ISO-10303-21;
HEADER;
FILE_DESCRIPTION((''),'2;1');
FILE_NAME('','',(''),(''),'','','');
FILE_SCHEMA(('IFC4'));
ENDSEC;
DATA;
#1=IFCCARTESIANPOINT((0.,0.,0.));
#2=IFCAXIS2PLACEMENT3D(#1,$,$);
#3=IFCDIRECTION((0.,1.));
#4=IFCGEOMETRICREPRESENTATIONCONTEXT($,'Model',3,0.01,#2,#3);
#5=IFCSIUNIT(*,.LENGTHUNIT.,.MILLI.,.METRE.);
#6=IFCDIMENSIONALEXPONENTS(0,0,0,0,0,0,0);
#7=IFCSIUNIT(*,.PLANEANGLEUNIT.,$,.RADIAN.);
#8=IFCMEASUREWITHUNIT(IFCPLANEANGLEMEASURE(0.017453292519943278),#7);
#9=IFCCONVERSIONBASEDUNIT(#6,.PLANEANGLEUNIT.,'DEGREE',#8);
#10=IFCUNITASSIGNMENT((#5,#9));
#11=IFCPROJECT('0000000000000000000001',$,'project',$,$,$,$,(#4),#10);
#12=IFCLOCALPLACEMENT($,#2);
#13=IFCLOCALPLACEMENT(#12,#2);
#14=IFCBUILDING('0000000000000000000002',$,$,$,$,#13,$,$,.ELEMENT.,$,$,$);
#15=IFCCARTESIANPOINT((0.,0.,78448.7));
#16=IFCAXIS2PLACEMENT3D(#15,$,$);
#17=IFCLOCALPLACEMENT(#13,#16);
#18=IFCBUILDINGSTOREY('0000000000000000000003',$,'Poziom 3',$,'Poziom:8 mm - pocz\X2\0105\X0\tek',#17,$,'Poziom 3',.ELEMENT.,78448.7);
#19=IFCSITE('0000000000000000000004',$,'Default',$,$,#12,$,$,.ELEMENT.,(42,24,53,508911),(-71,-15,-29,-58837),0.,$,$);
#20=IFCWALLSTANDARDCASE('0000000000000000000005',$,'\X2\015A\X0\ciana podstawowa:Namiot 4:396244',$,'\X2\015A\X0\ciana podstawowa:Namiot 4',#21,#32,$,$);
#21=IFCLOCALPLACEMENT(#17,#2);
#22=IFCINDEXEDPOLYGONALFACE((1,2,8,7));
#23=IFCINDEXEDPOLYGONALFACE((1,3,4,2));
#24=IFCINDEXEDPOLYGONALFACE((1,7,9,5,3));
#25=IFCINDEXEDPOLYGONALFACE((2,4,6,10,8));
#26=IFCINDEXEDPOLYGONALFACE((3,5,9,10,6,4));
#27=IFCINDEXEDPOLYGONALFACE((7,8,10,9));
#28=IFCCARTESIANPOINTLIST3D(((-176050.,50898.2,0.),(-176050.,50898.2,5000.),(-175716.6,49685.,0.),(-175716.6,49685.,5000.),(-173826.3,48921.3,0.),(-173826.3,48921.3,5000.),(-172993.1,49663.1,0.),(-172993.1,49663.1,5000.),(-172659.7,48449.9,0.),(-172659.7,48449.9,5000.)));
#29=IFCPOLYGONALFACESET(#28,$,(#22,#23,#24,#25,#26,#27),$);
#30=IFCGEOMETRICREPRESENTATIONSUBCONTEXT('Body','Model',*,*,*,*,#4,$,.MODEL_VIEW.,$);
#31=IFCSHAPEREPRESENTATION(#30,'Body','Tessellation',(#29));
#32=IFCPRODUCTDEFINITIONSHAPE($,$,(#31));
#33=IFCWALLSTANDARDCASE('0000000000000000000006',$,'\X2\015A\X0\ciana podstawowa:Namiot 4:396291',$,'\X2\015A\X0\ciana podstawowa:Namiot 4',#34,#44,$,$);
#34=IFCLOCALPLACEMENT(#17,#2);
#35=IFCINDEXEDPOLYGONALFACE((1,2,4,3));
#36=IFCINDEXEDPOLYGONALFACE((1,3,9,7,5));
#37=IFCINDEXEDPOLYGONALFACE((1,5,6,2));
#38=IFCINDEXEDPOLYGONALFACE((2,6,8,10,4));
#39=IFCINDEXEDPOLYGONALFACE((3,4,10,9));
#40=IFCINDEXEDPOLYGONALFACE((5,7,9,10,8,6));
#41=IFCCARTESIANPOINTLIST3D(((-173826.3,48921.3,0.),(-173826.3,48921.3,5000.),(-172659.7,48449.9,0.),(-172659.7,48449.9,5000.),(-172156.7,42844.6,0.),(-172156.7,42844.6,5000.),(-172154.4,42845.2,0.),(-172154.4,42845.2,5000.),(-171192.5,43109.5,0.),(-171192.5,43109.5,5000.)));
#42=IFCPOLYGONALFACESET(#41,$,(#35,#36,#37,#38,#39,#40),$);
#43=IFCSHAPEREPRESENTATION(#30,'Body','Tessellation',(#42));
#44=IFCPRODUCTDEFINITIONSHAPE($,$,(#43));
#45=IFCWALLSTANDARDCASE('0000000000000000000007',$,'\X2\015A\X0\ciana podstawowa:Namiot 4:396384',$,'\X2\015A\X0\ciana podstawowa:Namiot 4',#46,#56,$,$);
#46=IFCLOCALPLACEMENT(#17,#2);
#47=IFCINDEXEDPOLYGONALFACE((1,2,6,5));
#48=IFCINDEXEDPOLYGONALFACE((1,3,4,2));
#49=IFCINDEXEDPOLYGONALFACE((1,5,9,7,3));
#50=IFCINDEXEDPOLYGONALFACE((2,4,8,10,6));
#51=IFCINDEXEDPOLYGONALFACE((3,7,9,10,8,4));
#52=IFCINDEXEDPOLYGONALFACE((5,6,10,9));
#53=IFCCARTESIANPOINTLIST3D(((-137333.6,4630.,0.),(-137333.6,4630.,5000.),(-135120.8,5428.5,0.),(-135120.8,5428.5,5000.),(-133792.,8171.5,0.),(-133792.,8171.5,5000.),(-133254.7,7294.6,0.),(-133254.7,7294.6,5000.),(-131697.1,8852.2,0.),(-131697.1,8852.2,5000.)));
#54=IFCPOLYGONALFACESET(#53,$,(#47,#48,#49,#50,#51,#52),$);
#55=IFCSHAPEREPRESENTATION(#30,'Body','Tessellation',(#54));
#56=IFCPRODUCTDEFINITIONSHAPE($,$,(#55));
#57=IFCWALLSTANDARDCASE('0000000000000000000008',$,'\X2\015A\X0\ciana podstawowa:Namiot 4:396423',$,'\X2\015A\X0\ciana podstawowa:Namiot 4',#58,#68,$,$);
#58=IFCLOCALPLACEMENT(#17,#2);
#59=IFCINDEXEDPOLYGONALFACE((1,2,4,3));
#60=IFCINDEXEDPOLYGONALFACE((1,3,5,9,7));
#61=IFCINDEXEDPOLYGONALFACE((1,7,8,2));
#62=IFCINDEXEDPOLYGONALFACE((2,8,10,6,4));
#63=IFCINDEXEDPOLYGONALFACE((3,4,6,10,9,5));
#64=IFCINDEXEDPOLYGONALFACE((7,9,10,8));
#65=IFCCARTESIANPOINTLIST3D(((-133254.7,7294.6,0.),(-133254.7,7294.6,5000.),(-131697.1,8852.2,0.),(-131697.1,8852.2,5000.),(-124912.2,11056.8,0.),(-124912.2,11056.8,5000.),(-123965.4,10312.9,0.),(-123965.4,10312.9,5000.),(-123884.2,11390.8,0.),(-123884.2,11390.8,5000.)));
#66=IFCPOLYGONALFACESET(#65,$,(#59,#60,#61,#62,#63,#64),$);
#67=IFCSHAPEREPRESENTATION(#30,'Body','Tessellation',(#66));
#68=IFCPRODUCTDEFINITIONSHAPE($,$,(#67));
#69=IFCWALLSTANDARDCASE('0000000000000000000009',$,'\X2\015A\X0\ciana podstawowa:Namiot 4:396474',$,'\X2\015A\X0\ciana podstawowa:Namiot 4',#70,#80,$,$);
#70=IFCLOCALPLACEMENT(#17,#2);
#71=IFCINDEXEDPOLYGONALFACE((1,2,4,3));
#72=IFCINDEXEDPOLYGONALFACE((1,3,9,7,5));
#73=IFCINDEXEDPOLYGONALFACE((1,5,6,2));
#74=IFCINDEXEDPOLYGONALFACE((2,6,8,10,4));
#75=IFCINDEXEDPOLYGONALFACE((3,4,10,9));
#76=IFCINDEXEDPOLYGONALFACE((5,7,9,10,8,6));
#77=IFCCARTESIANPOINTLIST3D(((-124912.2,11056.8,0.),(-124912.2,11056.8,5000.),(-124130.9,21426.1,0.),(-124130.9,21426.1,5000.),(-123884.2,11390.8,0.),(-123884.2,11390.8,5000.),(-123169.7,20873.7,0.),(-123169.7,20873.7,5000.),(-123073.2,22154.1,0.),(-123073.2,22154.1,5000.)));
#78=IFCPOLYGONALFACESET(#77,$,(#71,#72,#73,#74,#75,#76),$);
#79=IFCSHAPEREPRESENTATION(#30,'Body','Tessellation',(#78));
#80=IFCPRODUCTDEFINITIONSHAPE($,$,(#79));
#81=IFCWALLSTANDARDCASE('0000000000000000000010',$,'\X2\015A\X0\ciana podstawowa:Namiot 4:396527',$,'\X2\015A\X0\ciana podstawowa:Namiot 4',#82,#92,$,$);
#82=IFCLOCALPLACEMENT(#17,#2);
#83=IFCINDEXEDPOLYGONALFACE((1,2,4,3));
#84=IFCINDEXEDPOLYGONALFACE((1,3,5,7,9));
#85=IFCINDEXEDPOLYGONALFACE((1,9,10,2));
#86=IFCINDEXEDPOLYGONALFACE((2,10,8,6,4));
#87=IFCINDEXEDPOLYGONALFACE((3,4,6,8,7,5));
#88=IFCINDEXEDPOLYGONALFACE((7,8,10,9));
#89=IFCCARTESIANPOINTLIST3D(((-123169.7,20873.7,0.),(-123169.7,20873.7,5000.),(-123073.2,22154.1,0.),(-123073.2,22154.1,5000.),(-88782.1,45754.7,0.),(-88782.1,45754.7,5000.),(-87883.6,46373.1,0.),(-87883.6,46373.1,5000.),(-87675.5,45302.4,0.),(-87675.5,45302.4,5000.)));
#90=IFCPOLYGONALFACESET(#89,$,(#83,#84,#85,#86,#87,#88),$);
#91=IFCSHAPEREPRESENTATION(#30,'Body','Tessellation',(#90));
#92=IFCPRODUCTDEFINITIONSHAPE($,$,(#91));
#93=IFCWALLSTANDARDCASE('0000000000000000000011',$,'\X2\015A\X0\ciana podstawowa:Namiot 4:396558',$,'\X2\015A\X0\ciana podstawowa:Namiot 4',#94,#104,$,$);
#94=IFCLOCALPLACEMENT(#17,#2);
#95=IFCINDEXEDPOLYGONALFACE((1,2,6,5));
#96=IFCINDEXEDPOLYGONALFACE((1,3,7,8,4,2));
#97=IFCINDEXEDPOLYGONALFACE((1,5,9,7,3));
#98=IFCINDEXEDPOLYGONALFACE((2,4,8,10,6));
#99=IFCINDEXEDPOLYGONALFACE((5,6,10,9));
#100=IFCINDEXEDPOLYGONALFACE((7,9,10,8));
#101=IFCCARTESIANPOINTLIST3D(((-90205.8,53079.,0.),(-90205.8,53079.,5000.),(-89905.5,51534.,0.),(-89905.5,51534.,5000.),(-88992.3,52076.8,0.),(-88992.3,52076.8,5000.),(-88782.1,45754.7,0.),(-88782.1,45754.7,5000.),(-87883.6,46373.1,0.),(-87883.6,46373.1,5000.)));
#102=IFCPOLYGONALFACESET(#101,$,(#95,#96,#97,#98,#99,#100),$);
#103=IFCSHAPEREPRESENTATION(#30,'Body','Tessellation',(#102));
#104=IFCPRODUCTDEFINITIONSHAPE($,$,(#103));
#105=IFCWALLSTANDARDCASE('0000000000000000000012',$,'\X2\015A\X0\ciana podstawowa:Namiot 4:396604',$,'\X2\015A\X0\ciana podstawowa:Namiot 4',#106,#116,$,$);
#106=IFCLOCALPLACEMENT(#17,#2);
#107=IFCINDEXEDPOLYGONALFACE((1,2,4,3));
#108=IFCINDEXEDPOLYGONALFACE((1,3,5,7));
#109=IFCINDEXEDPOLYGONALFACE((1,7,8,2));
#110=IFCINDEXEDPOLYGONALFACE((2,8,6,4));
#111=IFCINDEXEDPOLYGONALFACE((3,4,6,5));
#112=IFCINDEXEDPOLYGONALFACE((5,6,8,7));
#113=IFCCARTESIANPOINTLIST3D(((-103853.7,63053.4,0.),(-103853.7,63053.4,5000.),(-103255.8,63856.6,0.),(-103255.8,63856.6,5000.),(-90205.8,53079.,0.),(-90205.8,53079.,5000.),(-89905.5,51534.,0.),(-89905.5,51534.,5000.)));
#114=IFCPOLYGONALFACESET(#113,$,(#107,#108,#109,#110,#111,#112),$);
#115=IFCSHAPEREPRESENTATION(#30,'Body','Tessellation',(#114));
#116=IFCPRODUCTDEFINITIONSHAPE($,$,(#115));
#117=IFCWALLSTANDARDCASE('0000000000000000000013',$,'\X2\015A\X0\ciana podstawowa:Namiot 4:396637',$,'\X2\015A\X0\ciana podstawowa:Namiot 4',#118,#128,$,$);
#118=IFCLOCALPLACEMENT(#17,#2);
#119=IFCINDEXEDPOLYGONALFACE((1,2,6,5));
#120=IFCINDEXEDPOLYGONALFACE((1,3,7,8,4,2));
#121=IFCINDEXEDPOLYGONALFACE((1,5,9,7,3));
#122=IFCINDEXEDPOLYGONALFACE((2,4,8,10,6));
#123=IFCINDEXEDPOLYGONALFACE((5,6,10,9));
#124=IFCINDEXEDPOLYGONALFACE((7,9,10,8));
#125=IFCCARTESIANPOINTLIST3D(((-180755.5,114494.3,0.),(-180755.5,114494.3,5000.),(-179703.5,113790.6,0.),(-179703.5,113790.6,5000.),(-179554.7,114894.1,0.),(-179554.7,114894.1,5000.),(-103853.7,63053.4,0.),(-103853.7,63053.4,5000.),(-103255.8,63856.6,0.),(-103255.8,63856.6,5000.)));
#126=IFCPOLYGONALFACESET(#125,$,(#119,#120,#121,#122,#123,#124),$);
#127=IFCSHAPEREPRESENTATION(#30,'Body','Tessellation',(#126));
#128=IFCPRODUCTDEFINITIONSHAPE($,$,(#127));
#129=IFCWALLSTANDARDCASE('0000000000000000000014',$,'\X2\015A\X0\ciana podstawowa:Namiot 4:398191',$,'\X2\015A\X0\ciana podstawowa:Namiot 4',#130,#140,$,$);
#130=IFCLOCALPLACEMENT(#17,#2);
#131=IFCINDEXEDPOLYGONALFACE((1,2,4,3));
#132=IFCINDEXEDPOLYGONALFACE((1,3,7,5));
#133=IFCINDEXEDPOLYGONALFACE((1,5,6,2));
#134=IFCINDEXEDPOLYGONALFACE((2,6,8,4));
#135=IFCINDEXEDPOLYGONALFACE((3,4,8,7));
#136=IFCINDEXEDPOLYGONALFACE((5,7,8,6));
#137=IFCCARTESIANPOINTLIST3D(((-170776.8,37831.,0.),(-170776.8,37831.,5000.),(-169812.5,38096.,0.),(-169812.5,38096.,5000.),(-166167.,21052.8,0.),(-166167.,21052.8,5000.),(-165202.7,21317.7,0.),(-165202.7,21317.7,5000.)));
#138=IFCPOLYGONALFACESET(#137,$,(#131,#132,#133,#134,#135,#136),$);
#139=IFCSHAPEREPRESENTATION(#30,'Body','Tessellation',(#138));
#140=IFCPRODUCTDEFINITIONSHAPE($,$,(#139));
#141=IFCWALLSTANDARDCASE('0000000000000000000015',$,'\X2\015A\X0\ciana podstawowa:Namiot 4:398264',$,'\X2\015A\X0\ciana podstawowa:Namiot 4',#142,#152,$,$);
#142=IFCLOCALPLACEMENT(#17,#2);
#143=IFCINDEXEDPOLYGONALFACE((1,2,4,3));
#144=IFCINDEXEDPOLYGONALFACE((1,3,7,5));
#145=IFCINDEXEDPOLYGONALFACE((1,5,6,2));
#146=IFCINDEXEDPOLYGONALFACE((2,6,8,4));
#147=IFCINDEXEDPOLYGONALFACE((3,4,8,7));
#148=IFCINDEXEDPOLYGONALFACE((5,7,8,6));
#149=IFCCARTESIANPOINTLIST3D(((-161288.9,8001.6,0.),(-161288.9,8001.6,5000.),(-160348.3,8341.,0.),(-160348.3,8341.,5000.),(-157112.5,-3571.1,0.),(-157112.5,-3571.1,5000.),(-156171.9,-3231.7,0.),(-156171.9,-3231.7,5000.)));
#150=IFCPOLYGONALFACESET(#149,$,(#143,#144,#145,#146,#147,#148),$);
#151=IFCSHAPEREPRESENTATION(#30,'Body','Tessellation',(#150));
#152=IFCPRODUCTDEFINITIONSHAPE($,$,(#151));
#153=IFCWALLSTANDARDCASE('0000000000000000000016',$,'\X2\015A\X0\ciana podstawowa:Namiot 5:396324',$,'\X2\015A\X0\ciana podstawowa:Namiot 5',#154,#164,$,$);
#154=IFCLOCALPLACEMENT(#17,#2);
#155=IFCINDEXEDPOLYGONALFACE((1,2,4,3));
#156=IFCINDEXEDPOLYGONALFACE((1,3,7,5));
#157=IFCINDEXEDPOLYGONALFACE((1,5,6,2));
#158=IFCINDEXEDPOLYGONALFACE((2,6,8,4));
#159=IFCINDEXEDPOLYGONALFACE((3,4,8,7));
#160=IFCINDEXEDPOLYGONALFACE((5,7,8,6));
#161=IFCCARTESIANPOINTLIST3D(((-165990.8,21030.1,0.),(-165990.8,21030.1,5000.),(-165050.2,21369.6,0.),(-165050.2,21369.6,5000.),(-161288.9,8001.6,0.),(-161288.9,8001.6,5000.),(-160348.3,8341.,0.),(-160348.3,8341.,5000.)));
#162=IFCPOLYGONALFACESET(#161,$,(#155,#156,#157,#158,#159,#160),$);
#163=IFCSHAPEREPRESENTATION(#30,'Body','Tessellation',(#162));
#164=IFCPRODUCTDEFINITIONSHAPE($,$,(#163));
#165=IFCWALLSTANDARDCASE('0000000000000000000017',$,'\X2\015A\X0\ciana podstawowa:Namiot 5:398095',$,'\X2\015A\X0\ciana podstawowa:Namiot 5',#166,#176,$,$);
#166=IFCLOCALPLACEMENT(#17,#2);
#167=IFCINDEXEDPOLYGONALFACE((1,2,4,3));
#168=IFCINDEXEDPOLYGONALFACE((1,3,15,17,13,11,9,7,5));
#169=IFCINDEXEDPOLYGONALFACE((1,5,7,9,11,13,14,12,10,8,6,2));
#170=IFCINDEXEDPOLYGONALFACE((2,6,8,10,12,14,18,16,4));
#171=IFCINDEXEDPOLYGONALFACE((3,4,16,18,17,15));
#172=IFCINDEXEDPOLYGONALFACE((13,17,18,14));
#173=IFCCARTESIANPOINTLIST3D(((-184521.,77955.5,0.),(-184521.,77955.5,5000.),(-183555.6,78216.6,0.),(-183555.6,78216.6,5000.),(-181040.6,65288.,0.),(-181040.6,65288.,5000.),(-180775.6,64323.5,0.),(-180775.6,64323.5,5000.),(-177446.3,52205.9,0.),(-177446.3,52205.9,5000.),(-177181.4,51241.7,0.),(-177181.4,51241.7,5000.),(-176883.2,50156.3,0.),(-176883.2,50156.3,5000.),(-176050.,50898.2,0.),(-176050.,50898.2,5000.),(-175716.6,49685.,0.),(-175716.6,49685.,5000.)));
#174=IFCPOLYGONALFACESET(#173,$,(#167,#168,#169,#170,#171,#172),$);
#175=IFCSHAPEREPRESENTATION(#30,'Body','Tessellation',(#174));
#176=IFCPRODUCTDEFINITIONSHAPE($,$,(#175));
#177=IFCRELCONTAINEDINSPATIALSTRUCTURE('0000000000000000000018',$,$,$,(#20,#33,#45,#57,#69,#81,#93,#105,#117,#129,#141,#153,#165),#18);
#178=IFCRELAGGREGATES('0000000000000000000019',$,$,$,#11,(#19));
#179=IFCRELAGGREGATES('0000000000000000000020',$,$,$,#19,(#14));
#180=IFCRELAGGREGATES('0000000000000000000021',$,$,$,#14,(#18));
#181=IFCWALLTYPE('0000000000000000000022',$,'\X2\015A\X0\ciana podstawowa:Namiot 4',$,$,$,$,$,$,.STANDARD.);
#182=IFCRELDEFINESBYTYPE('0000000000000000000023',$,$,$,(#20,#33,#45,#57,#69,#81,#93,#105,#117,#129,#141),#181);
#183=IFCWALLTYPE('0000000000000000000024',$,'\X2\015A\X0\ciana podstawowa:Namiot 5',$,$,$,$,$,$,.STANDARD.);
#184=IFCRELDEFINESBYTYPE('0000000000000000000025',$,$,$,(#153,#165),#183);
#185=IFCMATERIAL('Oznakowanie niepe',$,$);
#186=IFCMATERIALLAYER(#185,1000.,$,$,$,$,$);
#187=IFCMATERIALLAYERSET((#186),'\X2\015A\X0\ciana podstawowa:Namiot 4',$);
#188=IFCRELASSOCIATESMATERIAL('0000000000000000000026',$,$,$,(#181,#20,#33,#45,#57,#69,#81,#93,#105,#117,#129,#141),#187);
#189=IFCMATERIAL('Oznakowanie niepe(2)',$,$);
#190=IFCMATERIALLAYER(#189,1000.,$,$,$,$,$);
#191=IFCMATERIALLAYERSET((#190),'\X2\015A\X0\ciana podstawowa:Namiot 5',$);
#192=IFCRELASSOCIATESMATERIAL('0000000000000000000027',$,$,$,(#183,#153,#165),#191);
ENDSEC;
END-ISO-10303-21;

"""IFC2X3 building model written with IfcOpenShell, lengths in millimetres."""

from ifc_helpers import new_model, entity, si_unit, converted_unit, direction, frame, frame_2d, origin, place, context, subcontext, project, spatial, polyline, rectangle, outline, extrude, material, layer, layer_set, layer_usage, type_object, element, save


model = new_model("IFC2X3")

# Units and contexts
model_context = context("Model", 3, precision=0.01, world=origin(), true_north=direction((0.0, 1.0)))
body_context = subcontext(model_context, "Body", "Model", "MODEL_VIEW")
ifc_project = project(units=[si_unit("LENGTHUNIT", "METRE", prefix="MILLI"), converted_unit("PLANEANGLEUNIT", "DEGREE", entity("IfcPlaneAngleMeasure", 0.017453292519943278), si_unit("PLANEANGLEUNIT", "RADIAN"), dimensions=[0, 0, 0, 0, 0, 0, 0])], contexts=[model_context])

# Site, building, storey
site_placement = place(None, origin())
site = spatial("IfcSite", under=ifc_project, at=site_placement, Name="Default", CompositionType="ELEMENT", RefLatitude=(42, 24, 53, 508911), RefLongitude=(-71, -15, -29, -58837), RefElevation=0.0)
building_placement = place(site_placement, origin())
building = spatial("IfcBuilding", under=site, at=building_placement, CompositionType="ELEMENT")
storey_placement = place(building_placement, frame((0.0, 0.0, 78448.7)))
storey = spatial("IfcBuildingStorey", under=building, at=storey_placement, Name="Poziom 3", ObjectType="Poziom:8 mm - początek", LongName="Poziom 3", CompositionType="ELEMENT", Elevation=78448.7)

# Walls
ifc_material_1 = material(Name="Oznakowanie niepe")
ifc_layer_1 = layer(ifc_material_1, 1000.0)
ifc_layer_set_1 = layer_set([ifc_layer_1], Name="Ściana podstawowa:Namiot 4")
ifc_layer_usage_1 = layer_usage(ifc_layer_set_1, "AXIS2", "NEGATIVE", 500.0)
wall_type_1 = type_object("IfcWallType", Name="Ściana podstawowa:Namiot 4", PredefinedType="STANDARD", material=ifc_layer_set_1)
wall_1_placement = place(storey_placement, frame((-176237.3, 50434.6, 0.0), z_axis=(0.0, 0.0, 1.0), x_axis=(0.927184, -0.374607, 0.0)))
element("IfcWallStandardCase", 1, at=wall_1_placement, inside=storey, type_object=wall_type_1, material=ifc_layer_usage_1, Name="Ściana podstawowa:Namiot 4:396244", ObjectType="Ściana podstawowa:Namiot 4", context=body_context, shape_type="SweptSolid", body=[
    extrude(outline(polyline([(4060.5, -500.0), (3297.0, 500.0), (0.0, 500.0), (763.5, -500.0), (2802.3, -500.0), (4060.5, -500.0)])), origin(), (0.0, 0.0, 1.0), 5000.0),
])
ifc_layer_usage_2 = layer_usage(ifc_layer_set_1, "AXIS2", "NEGATIVE", 500.0)
wall_2_placement = place(storey_placement, frame((-173344.1, 49053.7, 0.0), z_axis=(0.0, 0.0, 1.0), x_axis=(0.264931, -0.964267, 0.0)))
element("IfcWallStandardCase", 2, at=wall_2_placement, inside=storey, type_object=wall_type_1, material=ifc_layer_usage_2, Name="Ściana podstawowa:Namiot 4:396291", ObjectType="Ściana podstawowa:Namiot 4", context=body_context, shape_type="SweptSolid", body=[
    extrude(outline(polyline([(6301.8, -500.0), (6301.8, -497.6), (6301.8, 500.0), (763.5, 500.0), (0.0, -500.0), (6301.8, -500.0)])), origin(), (0.0, 0.0, 1.0), 5000.0),
])
ifc_layer_usage_3 = layer_usage(ifc_layer_set_1, "AXIS2", "NEGATIVE", 500.0)
wall_3_placement = place(storey_placement, frame((-136980.0, 4276.4, 0.0), z_axis=(0.0, 0.0, 1.0), x_axis=(0.707107, 0.707107, 0.0)))
element("IfcWallStandardCase", 3, at=wall_3_placement, inside=storey, type_object=wall_type_1, material=ifc_layer_usage_3, Name="Ściana podstawowa:Namiot 4:396384", ObjectType="Ściana podstawowa:Namiot 4", context=body_context, shape_type="SweptSolid", body=[
    extrude(outline(polyline([(6971.1, -500.0), (5008.5, 500.0), (0.0, 500.0), (2129.3, -500.0), (4768.4, -500.0), (6971.1, -500.0)])), origin(), (0.0, 0.0, 1.0), 5000.0),
])
ifc_layer_usage_4 = layer_usage(ifc_layer_set_1, "AXIS2", "NEGATIVE", 500.0)
wall_4_placement = place(storey_placement, frame((-133409.2, 7770.2, 0.0), z_axis=(0.0, 0.0, 1.0), x_axis=(0.951057, 0.309017, 0.0)))
element("IfcWallStandardCase", 4, at=wall_4_placement, inside=storey, type_object=wall_type_1, material=ifc_layer_usage_4, Name="Ściana podstawowa:Namiot 4:396423", ObjectType="Ściana podstawowa:Namiot 4", context=body_context, shape_type="SweptSolid", body=[
    extrude(outline(polyline([(9767.4, -500.0), (10177.7, 500.0), (9096.8, 500.0), (1962.6, 500.0), (0.0, -500.0), (9767.4, -500.0)])), origin(), (0.0, 0.0, 1.0), 5000.0),
])
ifc_layer_usage_5 = layer_usage(ifc_layer_set_1, "AXIS2", "NEGATIVE", 500.0)
wall_5_placement = place(storey_placement, frame((-124413.6, 11019.2, 0.0), z_axis=(0.0, 0.0, 1.0), x_axis=(0.075129, 0.997174, 0.0)))
element("IfcWallStandardCase", 5, at=wall_5_placement, inside=storey, type_object=wall_type_1, material=ifc_layer_usage_5, Name="Ściana podstawowa:Namiot 4:396474", ObjectType="Ściana podstawowa:Namiot 4", context=body_context, shape_type="SweptSolid", body=[
    extrude(outline(polyline([(11204.1, -500.0), (10398.8, 500.0), (0.0, 500.0), (410.3, -500.0), (9920.1, -500.0), (11204.1, -500.0)])), origin(), (0.0, 0.0, 1.0), 5000.0),
])
ifc_layer_usage_6 = layer_usage(ifc_layer_set_1, "AXIS2", "NEGATIVE", 500.0)
wall_6_placement = place(storey_placement, frame((-123453.2, 21285.6, 0.0), z_axis=(0.0, 0.0, 1.0), x_axis=(0.823755, 0.566945, 0.0)))
element("IfcWallStandardCase", 6, at=wall_6_placement, inside=storey, type_object=wall_type_1, material=ifc_layer_usage_6, Name="Ściana podstawowa:Namiot 4:396527", ObjectType="Ściana podstawowa:Namiot 4", context=body_context, shape_type="SweptSolid", body=[
    extrude(outline(polyline([(43088.3, -500.0), (43523.9, 500.0), (42433.1, 500.0), (805.3, 500.0), (0.0, -500.0), (43088.3, -500.0)])), origin(), (0.0, 0.0, 1.0), 5000.0),
])
ifc_layer_usage_7 = layer_usage(ifc_layer_set_1, "AXIS2", "NEGATIVE", 500.0)
wall_7_placement = place(storey_placement, frame((-88291.3, 45850.1, 0.0), z_axis=(0.0, 0.0, 1.0), x_axis=(-0.190809, 0.981627, 0.0)))
element("IfcWallStandardCase", 7, at=wall_7_placement, inside=storey, type_object=wall_type_1, material=ifc_layer_usage_7, Name="Ściana podstawowa:Namiot 4:396558", ObjectType="Ściana podstawowa:Namiot 4", context=body_context, shape_type="SweptSolid", body=[
    extrude(outline(polyline([(6246.0, -500.0), (7461.3, 500.0), (5887.5, 500.0), (0.0, 500.0), (435.6, -500.0), (6246.0, -500.0)])), origin(), (0.0, 0.0, 1.0), 5000.0),
])
ifc_layer_usage_8 = layer_usage(ifc_layer_set_1, "AXIS2", "NEGATIVE", 500.0)
wall_8_placement = place(storey_placement, frame((-89587.1, 51919.6, 0.0), z_axis=(0.0, 0.0, 1.0), x_axis=(-0.771044, 0.636782, 0.0)))
element("IfcWallStandardCase", 8, at=wall_8_placement, inside=storey, type_object=wall_type_1, material=ifc_layer_usage_8, Name="Ściana podstawowa:Namiot 4:396604", ObjectType="Ściana podstawowa:Namiot 4", context=body_context, shape_type="SweptSolid", body=[
    extrude(outline(polyline([(18140.4, -500.0), (18090.0, 500.0), (0.0, 500.0), (1215.4, -500.0), (18140.4, -500.0)])), origin(), (0.0, 0.0, 1.0), 5000.0),
])
ifc_layer_usage_9 = layer_usage(ifc_layer_set_1, "AXIS2", "NEGATIVE", 500.0)
wall_9_placement = place(storey_placement, frame((-103533.8, 63441.0, 0.0), z_axis=(0.0, 0.0, 1.0), x_axis=(-0.831186, 0.555994, 0.0)))
element("IfcWallStandardCase", 9, at=wall_9_placement, inside=storey, type_object=wall_type_1, material=ifc_layer_usage_9, Name="Ściana podstawowa:Namiot 4:396637", ObjectType="Ściana podstawowa:Namiot 4", context=body_context, shape_type="SweptSolid", body=[
    extrude(outline(polyline([(91795.2, -500.0), (92571.0, 500.0), (91305.3, 500.0), (50.4, 500.0), (0.0, -500.0), (91795.2, -500.0)])), origin(), (0.0, 0.0, 1.0), 5000.0),
])
ifc_layer_usage_10 = layer_usage(ifc_layer_set_1, "AXIS2", "NEGATIVE", 500.0)
wall_10_placement = place(storey_placement, frame((-170294.6, 37963.5, 0.0), z_axis=(0.0, 0.0, 1.0), x_axis=(0.264931, -0.964267, 0.0)))
element("IfcWallStandardCase", 10, at=wall_10_placement, inside=storey, type_object=wall_type_1, material=ifc_layer_usage_10, Name="Ściana podstawowa:Namiot 4:398191", ObjectType="Ściana podstawowa:Namiot 4", context=body_context, shape_type="SweptSolid", body=[
    extrude(rectangle(XDim=17400.0, YDim=1000.0, at=frame_2d((8700.0, 0.0), x_axis=(-1.0, 0.0))), origin(), (0.0, 0.0, 1.0), 5000.0),
])
ifc_layer_usage_11 = layer_usage(ifc_layer_set_1, "AXIS2", "NEGATIVE", 500.0)
wall_11_placement = place(storey_placement, frame((-160818.6, 8171.3, 0.0), z_axis=(0.0, 0.0, 1.0), x_axis=(0.339458, -0.940621, 0.0)))
element("IfcWallStandardCase", 11, at=wall_11_placement, inside=storey, type_object=wall_type_1, material=ifc_layer_usage_11, Name="Ściana podstawowa:Namiot 4:398264", ObjectType="Ściana podstawowa:Namiot 4", context=body_context, shape_type="SweptSolid", body=[
    extrude(rectangle(XDim=12303.2, YDim=1000.0, at=frame_2d((6151.6, 0.0), x_axis=(-1.0, 0.0))), origin(), (0.0, 0.0, 1.0), 5000.0),
])
ifc_material_2 = material(Name="Oznakowanie niepe(2)")
ifc_layer_2 = layer(ifc_material_2, 1000.0)
ifc_layer_set_2 = layer_set([ifc_layer_2], Name="Ściana podstawowa:Namiot 5")
ifc_layer_usage_12 = layer_usage(ifc_layer_set_2, "AXIS2", "NEGATIVE", 500.0)
wall_type_2 = type_object("IfcWallType", Name="Ściana podstawowa:Namiot 5", PredefinedType="STANDARD", material=ifc_layer_set_2)
wall_12_placement = place(storey_placement, frame((-165520.5, 21199.8, 0.0), z_axis=(0.0, 0.0, 1.0), x_axis=(0.339458, -0.940621, 0.0)))
element("IfcWallStandardCase", 12, at=wall_12_placement, inside=storey, type_object=wall_type_2, material=ifc_layer_usage_12, Name="Ściana podstawowa:Namiot 5:396324", ObjectType="Ściana podstawowa:Namiot 5", context=body_context, shape_type="SweptSolid", body=[
    extrude(rectangle(XDim=13851.0, YDim=1000.0, at=frame_2d((6925.5, 0.0), x_axis=(-1.0, 0.0))), origin(), (0.0, 0.0, 1.0), 5000.0),
])
ifc_layer_usage_13 = layer_usage(ifc_layer_set_2, "AXIS2", "NEGATIVE", 500.0)
wall_13_placement = place(storey_placement, frame((-184038.8, 78088.0, 0.0), z_axis=(0.0, 0.0, 1.0), x_axis=(0.264931, -0.964267, 0.0)))
element("IfcWallStandardCase", 13, at=wall_13_placement, inside=storey, type_object=wall_type_2, material=ifc_layer_usage_13, Name="Ściana podstawowa:Namiot 5:398095", ObjectType="Ściana podstawowa:Namiot 5", context=body_context, shape_type="SweptSolid", body=[
    extrude(outline(polyline([(28829.3, -500.0), (29592.8, 500.0), (28334.7, 500.0), (4.0, 500.0), (0.0, -500.0), (13136.9, -500.0), (14137.2, -500.0), (26703.8, -500.0), (27703.8, -500.0), (28829.3, -500.0)])), origin(), (0.0, 0.0, 1.0), 5000.0),
])

save(model, "model.ifc")
